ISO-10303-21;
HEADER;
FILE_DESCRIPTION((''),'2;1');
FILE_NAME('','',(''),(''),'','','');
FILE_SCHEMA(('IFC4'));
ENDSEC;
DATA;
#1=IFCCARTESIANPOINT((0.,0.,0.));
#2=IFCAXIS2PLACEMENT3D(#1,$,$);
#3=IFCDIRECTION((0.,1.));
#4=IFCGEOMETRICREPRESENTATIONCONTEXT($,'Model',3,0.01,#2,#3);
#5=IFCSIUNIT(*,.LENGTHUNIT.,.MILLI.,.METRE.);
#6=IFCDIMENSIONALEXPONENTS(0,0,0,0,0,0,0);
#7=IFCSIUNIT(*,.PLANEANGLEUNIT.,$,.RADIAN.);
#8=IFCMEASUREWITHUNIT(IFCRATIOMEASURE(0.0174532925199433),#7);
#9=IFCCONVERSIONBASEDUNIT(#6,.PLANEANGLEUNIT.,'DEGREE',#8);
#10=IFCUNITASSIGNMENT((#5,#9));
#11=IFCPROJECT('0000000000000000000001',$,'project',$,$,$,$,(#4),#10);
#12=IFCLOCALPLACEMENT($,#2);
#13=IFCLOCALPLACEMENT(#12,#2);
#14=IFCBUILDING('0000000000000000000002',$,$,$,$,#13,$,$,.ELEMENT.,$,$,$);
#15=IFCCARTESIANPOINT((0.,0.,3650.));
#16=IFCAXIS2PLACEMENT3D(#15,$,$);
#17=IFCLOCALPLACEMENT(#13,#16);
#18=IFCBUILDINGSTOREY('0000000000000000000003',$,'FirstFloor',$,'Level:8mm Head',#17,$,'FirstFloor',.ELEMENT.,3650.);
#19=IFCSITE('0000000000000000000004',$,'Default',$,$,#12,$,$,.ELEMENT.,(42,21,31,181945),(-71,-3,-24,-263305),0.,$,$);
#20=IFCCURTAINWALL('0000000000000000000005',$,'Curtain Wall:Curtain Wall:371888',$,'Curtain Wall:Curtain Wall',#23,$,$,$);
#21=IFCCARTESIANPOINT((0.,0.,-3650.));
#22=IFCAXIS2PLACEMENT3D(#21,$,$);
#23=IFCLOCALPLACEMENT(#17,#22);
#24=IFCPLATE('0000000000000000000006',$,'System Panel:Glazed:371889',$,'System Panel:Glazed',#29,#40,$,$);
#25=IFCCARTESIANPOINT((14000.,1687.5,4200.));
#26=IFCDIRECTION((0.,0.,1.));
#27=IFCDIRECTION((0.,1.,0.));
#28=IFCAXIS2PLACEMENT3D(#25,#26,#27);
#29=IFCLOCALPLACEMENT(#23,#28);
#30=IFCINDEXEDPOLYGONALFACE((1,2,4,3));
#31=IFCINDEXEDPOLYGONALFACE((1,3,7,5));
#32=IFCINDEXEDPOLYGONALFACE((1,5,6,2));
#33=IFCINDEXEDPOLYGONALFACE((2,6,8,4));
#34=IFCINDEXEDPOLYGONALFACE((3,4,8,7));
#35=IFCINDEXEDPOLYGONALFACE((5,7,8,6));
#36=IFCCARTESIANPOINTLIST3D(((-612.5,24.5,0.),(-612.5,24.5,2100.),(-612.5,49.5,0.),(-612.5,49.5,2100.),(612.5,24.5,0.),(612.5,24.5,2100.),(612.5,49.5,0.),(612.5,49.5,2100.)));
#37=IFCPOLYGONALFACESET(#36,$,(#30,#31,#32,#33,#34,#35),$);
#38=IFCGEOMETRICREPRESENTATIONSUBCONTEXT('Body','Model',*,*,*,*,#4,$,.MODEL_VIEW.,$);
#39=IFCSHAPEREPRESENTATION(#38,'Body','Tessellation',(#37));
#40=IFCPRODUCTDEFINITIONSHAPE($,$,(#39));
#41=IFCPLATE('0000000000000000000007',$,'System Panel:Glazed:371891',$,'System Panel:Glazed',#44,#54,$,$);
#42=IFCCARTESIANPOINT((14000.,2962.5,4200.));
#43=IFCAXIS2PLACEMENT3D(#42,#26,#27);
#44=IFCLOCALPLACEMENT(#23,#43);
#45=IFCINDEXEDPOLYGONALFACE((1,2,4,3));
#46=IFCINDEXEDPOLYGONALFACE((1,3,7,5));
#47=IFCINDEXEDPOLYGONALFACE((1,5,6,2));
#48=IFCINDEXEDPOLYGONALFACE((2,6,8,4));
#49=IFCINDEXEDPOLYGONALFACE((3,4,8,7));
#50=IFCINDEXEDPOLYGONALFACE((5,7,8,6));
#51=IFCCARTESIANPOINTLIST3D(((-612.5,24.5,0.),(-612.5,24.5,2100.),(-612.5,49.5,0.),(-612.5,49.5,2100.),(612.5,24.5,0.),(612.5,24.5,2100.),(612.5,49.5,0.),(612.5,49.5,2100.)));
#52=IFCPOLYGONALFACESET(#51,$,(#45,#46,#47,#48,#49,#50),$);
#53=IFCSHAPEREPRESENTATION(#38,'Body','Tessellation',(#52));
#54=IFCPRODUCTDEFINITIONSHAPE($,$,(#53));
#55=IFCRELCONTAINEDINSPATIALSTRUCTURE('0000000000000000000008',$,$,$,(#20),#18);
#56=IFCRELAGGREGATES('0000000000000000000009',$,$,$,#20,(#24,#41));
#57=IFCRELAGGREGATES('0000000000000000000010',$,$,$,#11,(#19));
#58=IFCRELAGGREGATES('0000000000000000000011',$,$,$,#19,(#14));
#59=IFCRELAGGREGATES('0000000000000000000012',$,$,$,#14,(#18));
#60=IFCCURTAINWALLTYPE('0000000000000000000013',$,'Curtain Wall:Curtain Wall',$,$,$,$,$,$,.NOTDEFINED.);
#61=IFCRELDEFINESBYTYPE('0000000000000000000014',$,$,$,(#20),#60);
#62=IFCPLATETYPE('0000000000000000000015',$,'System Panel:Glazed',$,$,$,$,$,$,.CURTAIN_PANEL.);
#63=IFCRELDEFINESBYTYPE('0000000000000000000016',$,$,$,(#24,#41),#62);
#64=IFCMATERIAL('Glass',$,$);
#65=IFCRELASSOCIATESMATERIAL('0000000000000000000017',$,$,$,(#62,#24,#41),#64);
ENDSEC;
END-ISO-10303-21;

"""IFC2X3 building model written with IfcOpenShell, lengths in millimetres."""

from ifc_helpers import new_model, entity, si_unit, converted_unit, direction, frame, origin, origin_2d_with_axis, place, context, subcontext, project, spatial, rectangle, extrude, source, transform, mapped, material, type_object, type_shapes, element, aggregate, save


model = new_model("IFC2X3")

# Units and contexts
model_context = context("Model", 3, precision=0.01, world=origin(), true_north=direction((0.0, 1.0)))
body_context = subcontext(model_context, "Body", "Model", "MODEL_VIEW")
ifc_project = project(units=[si_unit("LENGTHUNIT", "METRE", prefix="MILLI"), converted_unit("PLANEANGLEUNIT", "DEGREE", entity("IfcRatioMeasure", 0.0174532925199433), si_unit("PLANEANGLEUNIT", "RADIAN"), dimensions=[0, 0, 0, 0, 0, 0, 0])], contexts=[model_context])

# Site, building, storey
site_placement = place(None, origin())
site = spatial("IfcSite", under=ifc_project, at=site_placement, Name="Default", CompositionType="ELEMENT", RefLatitude=(42, 21, 31, 181945), RefLongitude=(-71, -3, -24, -263305), RefElevation=0.0)
building_placement = place(site_placement, origin())
building = spatial("IfcBuilding", under=site, at=building_placement, CompositionType="ELEMENT")
storey_placement = place(building_placement, frame((0.0, 0.0, 3650.0)))
storey = spatial("IfcBuildingStorey", under=building, at=storey_placement, Name="FirstFloor", ObjectType="Level:8mm Head", LongName="FirstFloor", CompositionType="ELEMENT", Elevation=3650.0)

# Curtain wall, plates
curtain_wall_type = type_object("IfcCurtainWallType", Name="Curtain Wall:Curtain Wall", PredefinedType="NOTDEFINED")
curtain_wall_placement = place(storey_placement, frame((0.0, 0.0, -3650.0)))
curtain_wall = element("IfcCurtainWall", 1, at=curtain_wall_placement, inside=storey, type_object=curtain_wall_type, Name="Curtain Wall:Curtain Wall:371888", ObjectType="Curtain Wall:Curtain Wall")
ifc_material_1 = material(Name="Glass")
plate_type = type_object("IfcPlateType", Name="System Panel:Glazed", PredefinedType="CURTAIN_PANEL", material=ifc_material_1)
shared_shape_1 = source(origin(), body_context, "Body", "SweptSolid", [
    extrude(rectangle(XDim=25.0, YDim=1225.0, at=origin_2d_with_axis()), frame((0.0, 37.0, 0.0), z_axis=(0.0, 0.0, 1.0), x_axis=(0.0, 1.0, 0.0)), (0.0, 0.0, 1.0), 2100.0),
])
type_shapes(plate_type, [shared_shape_1])
plate_1_placement = place(curtain_wall_placement, frame((14000.0, 1687.5, 4200.0), z_axis=(0.0, 0.0, 1.0), x_axis=(0.0, 1.0, 0.0)))
plate_1 = element("IfcPlate", 2, at=plate_1_placement, type_object=plate_type, material=ifc_material_1, Name="System Panel:Glazed:371889", ObjectType="System Panel:Glazed", context=body_context, shape_type="MappedRepresentation", body=[
    mapped(shared_shape_1, transform((0.0, 0.0, 0.0), scale=1.0)),
])
plate_2_placement = place(curtain_wall_placement, frame((14000.0, 2962.5, 4200.0), z_axis=(0.0, 0.0, 1.0), x_axis=(0.0, 1.0, 0.0)))
plate_2 = element("IfcPlate", 3, at=plate_2_placement, type_object=plate_type, material=ifc_material_1, Name="System Panel:Glazed:371891", ObjectType="System Panel:Glazed", context=body_context, shape_type="MappedRepresentation", body=[
    mapped(shared_shape_1, transform((0.0, 0.0, 0.0), scale=1.0)),
])
aggregate(curtain_wall, [plate_1, plate_2])

save(model, "model.ifc")
